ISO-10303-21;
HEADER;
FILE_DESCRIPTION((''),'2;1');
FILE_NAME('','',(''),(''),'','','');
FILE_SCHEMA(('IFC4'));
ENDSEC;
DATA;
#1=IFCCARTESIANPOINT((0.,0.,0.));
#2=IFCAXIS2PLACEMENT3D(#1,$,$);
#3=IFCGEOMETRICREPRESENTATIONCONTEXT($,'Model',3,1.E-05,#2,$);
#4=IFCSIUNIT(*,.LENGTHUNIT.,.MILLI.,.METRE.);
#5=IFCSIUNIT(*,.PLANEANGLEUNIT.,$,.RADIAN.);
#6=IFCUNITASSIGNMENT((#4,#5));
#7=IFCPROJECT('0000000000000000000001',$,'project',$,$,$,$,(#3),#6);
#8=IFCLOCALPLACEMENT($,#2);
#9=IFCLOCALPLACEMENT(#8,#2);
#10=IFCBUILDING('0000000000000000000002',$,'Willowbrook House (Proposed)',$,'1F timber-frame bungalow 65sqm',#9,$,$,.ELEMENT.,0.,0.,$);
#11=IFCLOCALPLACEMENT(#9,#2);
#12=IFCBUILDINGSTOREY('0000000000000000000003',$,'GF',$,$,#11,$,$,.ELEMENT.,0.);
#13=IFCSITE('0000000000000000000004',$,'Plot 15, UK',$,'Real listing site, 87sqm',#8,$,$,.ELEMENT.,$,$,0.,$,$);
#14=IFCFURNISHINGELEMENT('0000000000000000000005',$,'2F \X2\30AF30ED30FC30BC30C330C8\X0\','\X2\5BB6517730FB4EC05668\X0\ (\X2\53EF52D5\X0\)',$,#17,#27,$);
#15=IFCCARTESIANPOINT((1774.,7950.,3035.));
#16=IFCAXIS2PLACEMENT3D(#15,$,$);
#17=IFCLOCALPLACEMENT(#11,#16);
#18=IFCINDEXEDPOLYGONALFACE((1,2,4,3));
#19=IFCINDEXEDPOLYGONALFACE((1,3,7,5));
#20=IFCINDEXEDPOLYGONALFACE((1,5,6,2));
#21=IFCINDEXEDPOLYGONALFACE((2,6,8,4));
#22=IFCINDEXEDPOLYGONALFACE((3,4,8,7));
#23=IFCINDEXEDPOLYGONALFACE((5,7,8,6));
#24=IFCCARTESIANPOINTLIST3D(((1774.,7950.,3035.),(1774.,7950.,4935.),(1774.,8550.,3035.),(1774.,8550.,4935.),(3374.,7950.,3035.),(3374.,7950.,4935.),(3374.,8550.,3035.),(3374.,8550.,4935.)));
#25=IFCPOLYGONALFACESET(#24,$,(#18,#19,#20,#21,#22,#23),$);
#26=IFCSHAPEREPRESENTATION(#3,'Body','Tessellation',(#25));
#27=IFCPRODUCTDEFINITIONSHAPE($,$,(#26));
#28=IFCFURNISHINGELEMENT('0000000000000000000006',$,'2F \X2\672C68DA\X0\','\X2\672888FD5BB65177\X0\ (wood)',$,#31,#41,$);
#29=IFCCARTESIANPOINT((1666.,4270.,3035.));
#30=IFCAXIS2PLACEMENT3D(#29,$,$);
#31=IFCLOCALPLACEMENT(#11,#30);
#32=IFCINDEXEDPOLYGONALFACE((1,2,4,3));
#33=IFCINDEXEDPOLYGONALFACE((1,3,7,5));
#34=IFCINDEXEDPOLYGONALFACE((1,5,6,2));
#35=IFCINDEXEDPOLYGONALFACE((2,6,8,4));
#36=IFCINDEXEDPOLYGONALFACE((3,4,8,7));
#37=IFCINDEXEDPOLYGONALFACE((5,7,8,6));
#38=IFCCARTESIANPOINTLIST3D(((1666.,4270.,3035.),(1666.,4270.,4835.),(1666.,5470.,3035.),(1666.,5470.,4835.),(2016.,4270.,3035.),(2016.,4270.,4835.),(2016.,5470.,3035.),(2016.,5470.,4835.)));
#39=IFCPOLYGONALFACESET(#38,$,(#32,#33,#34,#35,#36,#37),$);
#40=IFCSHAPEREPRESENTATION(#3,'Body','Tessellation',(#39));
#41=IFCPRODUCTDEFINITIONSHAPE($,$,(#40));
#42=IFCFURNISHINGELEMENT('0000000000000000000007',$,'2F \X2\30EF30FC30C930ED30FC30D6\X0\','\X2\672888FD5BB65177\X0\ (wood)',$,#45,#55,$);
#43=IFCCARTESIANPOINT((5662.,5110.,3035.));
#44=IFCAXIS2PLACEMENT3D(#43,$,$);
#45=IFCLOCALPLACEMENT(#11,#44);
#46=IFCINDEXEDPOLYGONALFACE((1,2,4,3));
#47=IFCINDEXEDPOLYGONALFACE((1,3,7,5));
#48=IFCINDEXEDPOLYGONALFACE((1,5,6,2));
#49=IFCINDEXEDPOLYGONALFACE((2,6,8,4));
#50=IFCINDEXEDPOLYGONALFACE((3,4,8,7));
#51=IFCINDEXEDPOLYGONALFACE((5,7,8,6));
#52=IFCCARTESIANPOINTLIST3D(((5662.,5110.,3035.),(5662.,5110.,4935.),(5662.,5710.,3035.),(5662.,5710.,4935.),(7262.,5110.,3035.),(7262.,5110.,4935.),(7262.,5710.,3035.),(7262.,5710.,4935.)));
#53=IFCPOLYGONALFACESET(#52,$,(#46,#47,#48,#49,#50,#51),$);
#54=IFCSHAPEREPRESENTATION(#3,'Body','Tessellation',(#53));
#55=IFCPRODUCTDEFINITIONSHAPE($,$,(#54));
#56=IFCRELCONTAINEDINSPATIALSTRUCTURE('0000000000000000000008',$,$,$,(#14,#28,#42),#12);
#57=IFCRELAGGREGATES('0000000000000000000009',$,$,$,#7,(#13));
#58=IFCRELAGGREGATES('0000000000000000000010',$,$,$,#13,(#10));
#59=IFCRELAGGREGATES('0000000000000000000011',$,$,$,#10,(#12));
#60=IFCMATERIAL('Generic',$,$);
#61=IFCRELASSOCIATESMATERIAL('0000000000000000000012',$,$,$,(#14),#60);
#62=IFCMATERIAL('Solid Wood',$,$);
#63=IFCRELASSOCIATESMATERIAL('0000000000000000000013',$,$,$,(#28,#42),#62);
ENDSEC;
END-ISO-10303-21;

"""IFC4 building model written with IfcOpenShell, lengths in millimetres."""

from ifc_helpers import new_model, si_unit, frame, frame_2d, origin, place, context, project, spatial, rectangle, extrude, material, element, save


model = new_model("IFC4")

# Units and contexts
model_context = context("Model", 3, precision=1e-05, world=origin())
ifc_project = project(units=[si_unit("LENGTHUNIT", "METRE", prefix="MILLI"), si_unit("PLANEANGLEUNIT", "RADIAN")], contexts=[model_context])

# Site, building, storey
site_placement = place(None, origin())
site = spatial("IfcSite", under=ifc_project, at=site_placement, Name="Plot 15, UK", ObjectType="Real listing site, 87sqm", CompositionType="ELEMENT", RefElevation=0.0)
building_placement = place(site_placement, origin())
building = spatial("IfcBuilding", under=site, at=building_placement, Name="Willowbrook House (Proposed)", ObjectType="1F timber-frame bungalow 65sqm", CompositionType="ELEMENT", ElevationOfRefHeight=0.0, ElevationOfTerrain=0.0)
storey_placement = place(building_placement, origin())
storey = spatial("IfcBuildingStorey", under=building, at=storey_placement, Name="GF", CompositionType="ELEMENT", Elevation=0.0)

# Shared definitions
ifc_material_1 = material(Name="Solid Wood")

# Shared definitions
ifc_material_2 = material(Name="Generic")

# Furnishing elements
furnishing_1_placement = place(storey_placement, frame((1774.0, 7950.0, 3035.0)))
element("IfcFurnishingElement", 1, at=furnishing_1_placement, inside=storey, material=ifc_material_2, Name="2F クローゼット", Description="家具・什器 (可動)", context=model_context, shape_type="SweptSolid", body=[
    extrude(rectangle(XDim=1600.0, YDim=600.0, at=frame_2d((800.0, 300.0))), frame((1774.0, 7950.0, 3035.0)), (0.0, 0.0, 1.0), 1900.0),
])
furnishing_2_placement = place(storey_placement, frame((1666.0, 4270.0, 3035.0)))
element("IfcFurnishingElement", 2, at=furnishing_2_placement, inside=storey, material=ifc_material_1, Name="2F 本棚", Description="木製家具 (wood)", context=model_context, shape_type="SweptSolid", body=[
    extrude(rectangle(XDim=350.0, YDim=1200.0, at=frame_2d((175.0, 600.0))), frame((1666.0, 4270.0, 3035.0)), (0.0, 0.0, 1.0), 1800.0),
])
furnishing_3_placement = place(storey_placement, frame((5662.0, 5110.0, 3035.0)))
element("IfcFurnishingElement", 3, at=furnishing_3_placement, inside=storey, material=ifc_material_1, Name="2F ワードローブ", Description="木製家具 (wood)", context=model_context, shape_type="SweptSolid", body=[
    extrude(rectangle(XDim=1600.0, YDim=600.0, at=frame_2d((800.0, 300.0))), frame((5662.0, 5110.0, 3035.0)), (0.0, 0.0, 1.0), 1900.0),
])

save(model, "model.ifc")
